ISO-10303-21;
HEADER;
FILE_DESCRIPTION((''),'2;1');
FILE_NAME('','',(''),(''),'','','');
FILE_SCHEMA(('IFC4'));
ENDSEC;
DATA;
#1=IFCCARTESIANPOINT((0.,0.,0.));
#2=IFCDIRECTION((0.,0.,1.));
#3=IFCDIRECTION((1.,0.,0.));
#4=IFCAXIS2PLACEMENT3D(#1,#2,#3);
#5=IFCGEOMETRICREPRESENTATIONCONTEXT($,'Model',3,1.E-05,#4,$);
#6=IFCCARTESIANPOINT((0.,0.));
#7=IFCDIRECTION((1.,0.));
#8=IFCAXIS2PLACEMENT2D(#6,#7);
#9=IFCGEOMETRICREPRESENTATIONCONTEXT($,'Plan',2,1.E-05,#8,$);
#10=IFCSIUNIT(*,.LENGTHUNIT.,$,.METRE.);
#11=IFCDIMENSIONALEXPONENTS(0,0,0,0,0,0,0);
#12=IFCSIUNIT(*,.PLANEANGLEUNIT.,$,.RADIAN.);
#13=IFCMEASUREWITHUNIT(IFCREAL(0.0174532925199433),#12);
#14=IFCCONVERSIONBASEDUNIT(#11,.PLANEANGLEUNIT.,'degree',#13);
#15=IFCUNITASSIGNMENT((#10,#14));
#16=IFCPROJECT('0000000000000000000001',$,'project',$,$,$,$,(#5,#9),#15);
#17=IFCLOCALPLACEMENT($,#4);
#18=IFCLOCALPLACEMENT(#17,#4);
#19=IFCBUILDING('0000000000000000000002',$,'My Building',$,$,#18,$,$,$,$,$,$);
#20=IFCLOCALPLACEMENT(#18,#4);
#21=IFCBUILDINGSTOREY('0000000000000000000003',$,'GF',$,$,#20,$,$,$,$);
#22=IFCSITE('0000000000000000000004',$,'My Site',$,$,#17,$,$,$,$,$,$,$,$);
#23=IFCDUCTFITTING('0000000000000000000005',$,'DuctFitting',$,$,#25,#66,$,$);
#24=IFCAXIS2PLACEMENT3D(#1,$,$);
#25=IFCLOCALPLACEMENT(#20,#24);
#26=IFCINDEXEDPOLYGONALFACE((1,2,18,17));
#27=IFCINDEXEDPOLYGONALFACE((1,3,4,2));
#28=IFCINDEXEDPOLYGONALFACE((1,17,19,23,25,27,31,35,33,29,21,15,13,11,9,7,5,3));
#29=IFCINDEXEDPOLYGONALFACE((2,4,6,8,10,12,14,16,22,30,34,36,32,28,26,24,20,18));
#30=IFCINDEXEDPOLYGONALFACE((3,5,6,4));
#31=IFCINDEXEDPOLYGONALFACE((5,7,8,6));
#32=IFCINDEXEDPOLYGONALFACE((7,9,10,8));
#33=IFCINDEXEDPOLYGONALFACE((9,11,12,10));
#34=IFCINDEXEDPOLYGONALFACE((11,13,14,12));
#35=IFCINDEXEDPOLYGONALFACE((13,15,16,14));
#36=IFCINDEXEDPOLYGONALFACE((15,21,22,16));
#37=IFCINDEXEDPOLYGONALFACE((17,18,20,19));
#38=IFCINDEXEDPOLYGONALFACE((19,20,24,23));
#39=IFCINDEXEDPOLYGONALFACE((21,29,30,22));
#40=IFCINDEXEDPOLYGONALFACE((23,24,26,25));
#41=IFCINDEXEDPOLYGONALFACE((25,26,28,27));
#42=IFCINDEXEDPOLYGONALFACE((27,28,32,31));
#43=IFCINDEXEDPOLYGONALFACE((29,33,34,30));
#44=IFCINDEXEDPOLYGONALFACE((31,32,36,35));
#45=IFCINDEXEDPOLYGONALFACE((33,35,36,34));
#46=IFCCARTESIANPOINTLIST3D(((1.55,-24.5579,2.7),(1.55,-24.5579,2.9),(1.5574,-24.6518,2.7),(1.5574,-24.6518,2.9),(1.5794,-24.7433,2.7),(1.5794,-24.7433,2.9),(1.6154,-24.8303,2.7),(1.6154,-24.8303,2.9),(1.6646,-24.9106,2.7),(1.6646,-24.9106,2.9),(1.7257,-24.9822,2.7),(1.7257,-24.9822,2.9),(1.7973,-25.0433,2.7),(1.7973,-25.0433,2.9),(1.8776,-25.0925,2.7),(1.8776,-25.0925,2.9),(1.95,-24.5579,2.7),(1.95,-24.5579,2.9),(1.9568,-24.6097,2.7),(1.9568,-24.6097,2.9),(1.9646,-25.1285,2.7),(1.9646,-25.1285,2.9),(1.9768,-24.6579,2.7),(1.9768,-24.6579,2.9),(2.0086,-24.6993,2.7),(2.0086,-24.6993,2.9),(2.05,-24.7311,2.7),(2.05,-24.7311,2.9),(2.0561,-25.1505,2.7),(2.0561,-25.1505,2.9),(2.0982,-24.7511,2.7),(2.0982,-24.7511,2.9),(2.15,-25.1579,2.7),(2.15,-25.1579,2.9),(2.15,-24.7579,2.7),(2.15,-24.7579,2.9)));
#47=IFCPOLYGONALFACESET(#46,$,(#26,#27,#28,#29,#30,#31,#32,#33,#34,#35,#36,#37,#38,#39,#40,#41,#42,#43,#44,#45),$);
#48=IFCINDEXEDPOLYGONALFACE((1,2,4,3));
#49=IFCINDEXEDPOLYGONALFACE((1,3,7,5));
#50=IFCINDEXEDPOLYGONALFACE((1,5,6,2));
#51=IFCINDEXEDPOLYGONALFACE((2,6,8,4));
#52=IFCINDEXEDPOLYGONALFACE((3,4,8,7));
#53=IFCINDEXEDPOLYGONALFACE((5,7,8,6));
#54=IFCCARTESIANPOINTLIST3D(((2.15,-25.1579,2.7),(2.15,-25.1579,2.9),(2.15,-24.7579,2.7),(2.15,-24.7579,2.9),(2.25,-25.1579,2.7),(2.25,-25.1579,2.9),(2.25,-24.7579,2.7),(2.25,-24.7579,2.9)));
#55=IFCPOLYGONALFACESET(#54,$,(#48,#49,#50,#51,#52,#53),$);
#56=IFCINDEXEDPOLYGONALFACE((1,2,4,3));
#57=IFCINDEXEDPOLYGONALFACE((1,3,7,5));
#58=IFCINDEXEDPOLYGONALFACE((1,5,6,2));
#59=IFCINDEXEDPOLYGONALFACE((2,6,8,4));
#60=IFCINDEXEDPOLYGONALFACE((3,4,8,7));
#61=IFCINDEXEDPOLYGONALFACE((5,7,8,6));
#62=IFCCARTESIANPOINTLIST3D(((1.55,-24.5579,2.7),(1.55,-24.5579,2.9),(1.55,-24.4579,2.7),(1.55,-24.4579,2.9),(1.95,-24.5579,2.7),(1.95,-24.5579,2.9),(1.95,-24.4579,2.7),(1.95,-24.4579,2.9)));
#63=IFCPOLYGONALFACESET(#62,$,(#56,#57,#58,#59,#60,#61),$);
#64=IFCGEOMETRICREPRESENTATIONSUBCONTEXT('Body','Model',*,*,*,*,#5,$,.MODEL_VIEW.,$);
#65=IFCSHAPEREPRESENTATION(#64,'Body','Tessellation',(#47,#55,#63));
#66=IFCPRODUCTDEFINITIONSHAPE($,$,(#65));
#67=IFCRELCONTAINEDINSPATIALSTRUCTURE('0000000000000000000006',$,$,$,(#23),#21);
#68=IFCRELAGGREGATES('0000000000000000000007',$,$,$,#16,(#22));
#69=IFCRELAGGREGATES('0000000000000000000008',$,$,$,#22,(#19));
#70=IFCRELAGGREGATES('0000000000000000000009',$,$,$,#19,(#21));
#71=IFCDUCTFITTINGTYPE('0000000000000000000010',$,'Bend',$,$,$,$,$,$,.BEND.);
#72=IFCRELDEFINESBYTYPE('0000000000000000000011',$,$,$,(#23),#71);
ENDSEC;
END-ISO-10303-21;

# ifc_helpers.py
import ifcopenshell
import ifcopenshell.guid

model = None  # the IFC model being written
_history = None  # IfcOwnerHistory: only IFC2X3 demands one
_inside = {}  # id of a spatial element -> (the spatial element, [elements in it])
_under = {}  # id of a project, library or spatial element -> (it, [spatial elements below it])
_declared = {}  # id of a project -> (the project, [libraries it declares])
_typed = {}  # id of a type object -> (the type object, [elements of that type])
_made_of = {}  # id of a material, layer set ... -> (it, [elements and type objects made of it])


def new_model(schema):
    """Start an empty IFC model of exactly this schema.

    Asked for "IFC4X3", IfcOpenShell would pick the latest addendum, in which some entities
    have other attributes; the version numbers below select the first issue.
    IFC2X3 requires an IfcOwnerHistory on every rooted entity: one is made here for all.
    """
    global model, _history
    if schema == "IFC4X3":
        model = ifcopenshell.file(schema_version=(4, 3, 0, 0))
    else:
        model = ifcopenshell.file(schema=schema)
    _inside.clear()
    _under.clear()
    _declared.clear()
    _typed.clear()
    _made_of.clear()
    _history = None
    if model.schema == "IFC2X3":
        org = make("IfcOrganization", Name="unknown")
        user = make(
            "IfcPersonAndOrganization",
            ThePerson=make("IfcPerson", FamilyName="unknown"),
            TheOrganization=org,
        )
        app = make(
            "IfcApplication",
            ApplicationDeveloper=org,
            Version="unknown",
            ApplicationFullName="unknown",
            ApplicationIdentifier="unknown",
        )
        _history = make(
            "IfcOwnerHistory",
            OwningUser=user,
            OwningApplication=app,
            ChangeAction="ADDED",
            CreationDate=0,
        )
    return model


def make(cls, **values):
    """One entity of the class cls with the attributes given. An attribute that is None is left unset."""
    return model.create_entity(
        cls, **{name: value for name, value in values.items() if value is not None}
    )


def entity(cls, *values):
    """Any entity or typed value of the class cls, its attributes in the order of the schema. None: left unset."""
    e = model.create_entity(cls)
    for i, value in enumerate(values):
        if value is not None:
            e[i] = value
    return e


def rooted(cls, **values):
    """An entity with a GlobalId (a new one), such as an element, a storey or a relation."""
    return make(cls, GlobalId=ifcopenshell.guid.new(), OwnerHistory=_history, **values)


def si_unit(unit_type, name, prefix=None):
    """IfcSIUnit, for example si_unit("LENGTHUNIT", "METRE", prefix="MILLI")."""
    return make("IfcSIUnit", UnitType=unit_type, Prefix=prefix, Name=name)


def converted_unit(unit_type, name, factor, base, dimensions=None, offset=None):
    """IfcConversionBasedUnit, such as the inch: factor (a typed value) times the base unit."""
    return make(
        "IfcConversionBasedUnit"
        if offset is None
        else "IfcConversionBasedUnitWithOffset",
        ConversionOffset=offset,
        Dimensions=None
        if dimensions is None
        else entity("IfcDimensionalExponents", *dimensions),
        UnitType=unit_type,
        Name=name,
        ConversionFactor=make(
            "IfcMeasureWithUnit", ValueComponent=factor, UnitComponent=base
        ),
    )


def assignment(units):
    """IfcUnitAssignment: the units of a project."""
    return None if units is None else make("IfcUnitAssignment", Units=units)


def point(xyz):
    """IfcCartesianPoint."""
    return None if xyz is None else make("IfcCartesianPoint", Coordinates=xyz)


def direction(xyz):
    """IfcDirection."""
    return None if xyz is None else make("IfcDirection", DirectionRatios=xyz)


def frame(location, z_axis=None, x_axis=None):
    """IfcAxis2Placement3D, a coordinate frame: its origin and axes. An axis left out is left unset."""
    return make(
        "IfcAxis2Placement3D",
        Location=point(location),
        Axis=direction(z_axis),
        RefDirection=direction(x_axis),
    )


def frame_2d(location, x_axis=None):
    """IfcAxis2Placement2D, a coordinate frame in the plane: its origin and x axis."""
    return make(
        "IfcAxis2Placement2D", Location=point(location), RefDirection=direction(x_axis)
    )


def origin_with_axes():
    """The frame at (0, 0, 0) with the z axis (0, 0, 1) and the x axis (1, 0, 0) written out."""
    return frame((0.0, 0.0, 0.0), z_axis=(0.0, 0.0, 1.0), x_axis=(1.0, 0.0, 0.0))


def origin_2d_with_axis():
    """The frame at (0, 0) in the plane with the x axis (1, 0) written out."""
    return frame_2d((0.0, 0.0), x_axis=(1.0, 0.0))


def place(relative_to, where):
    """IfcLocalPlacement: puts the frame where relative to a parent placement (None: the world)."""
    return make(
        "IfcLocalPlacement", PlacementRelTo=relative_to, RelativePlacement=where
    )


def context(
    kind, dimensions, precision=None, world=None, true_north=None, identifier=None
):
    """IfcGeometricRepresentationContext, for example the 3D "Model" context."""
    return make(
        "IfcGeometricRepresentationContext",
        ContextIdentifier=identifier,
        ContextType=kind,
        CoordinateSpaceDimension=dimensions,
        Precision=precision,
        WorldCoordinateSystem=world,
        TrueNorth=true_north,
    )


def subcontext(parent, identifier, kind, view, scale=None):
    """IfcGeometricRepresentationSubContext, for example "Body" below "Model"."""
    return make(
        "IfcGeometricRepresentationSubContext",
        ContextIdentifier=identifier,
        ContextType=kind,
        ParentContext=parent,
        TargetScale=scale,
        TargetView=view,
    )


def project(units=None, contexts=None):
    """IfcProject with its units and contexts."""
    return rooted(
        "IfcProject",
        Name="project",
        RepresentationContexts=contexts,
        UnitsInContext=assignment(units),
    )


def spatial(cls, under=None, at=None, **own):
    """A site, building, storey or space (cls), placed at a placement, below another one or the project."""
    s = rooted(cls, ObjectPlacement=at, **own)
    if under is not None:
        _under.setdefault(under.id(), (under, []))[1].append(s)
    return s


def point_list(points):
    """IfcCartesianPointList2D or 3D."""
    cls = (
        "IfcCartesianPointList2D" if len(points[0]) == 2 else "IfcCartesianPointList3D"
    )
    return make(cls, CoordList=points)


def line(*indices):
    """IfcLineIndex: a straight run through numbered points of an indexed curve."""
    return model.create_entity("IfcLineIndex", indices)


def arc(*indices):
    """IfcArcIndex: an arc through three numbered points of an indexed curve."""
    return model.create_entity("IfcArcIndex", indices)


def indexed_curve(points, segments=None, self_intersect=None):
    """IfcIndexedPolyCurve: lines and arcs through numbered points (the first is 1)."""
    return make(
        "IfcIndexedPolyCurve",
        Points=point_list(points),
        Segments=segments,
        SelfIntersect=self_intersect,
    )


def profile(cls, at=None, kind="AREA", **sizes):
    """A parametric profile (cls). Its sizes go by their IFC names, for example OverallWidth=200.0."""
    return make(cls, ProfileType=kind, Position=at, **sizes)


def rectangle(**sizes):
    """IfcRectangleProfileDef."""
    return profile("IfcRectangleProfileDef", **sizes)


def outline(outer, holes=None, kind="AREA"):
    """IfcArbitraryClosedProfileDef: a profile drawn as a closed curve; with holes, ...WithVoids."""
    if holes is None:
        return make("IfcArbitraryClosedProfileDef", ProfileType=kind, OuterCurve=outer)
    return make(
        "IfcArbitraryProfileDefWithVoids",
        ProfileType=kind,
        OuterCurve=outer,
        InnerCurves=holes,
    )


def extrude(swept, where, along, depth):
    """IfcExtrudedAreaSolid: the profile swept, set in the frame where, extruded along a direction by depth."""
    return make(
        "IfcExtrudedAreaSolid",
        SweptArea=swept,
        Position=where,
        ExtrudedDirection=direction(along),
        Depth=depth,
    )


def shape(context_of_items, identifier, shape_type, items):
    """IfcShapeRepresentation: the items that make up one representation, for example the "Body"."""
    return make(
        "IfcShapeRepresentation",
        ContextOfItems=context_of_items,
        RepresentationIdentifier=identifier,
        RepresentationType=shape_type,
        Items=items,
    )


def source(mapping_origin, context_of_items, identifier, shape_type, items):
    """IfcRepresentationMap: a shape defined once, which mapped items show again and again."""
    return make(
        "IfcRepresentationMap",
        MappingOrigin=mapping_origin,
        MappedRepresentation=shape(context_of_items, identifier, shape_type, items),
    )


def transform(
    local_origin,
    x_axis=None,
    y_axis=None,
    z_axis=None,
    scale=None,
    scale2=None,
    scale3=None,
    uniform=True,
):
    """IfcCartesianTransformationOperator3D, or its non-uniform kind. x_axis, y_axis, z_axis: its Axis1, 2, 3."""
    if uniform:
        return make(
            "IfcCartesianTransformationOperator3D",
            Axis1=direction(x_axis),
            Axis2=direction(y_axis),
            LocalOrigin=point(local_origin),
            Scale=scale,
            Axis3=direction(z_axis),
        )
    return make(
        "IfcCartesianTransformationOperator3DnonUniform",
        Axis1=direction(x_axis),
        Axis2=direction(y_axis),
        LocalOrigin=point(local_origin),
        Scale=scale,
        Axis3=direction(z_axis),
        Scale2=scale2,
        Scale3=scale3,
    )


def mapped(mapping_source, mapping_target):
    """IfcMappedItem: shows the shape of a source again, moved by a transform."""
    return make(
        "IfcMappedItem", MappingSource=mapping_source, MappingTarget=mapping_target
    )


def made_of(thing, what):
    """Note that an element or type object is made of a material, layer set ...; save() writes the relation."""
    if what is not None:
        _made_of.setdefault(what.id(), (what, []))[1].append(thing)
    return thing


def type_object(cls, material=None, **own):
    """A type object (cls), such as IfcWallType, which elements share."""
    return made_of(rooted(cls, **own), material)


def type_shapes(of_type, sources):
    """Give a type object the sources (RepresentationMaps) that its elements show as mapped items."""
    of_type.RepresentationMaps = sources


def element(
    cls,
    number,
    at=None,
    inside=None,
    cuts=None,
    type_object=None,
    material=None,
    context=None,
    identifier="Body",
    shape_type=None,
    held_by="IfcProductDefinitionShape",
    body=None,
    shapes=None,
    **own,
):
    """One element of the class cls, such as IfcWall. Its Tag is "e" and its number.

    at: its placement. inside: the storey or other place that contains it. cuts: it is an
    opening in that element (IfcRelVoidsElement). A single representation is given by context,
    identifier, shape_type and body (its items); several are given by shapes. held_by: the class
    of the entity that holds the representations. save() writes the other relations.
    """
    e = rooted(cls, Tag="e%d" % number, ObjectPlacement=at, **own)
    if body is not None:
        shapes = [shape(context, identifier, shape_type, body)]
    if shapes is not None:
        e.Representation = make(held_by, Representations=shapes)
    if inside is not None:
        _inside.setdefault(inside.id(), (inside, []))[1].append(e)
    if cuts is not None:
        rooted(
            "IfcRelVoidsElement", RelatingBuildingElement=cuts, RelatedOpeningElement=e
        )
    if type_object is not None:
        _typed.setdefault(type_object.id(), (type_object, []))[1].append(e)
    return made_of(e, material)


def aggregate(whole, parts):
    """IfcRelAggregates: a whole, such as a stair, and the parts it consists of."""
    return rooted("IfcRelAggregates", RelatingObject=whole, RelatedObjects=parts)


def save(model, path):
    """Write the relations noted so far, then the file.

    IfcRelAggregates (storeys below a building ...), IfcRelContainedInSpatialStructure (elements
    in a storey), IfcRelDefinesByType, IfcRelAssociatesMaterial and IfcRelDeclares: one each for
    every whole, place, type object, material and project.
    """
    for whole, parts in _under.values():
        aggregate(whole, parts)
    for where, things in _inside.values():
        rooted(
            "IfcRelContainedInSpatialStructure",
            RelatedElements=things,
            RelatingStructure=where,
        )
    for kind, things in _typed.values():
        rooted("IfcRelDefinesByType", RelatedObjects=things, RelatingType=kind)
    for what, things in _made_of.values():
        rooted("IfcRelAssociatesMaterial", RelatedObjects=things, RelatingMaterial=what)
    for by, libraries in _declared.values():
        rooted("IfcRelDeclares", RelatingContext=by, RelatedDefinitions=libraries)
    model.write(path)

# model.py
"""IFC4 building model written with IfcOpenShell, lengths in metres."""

from ifc_helpers import new_model, entity, si_unit, converted_unit, frame, origin_with_axes, origin_2d_with_axis, place, context, subcontext, project, spatial, line, arc, indexed_curve, rectangle, outline, extrude, source, transform, mapped, type_object, type_shapes, element, save


model = new_model("IFC4")

# Units and contexts
model_context = context("Model", 3, precision=1e-05, world=origin_with_axes())
plan_context = context("Plan", 2, precision=1e-05, world=origin_2d_with_axis())
body_context_1 = subcontext(model_context, "Body", "Model", "MODEL_VIEW")
ifc_project = project(units=[si_unit("LENGTHUNIT", "METRE"), converted_unit("PLANEANGLEUNIT", "degree", entity("IfcReal", 0.0174532925199433), si_unit("PLANEANGLEUNIT", "RADIAN"), dimensions=[0, 0, 0, 0, 0, 0, 0])], contexts=[model_context, plan_context])

# Site, building, storey
site_placement = place(None, origin_with_axes())
site = spatial("IfcSite", under=ifc_project, at=site_placement, Name="My Site")
building_placement = place(site_placement, origin_with_axes())
building = spatial("IfcBuilding", under=site, at=building_placement, Name="My Building")
storey_placement = place(building_placement, origin_with_axes())
storey = spatial("IfcBuildingStorey", under=building, at=storey_placement, Name="GF")

# Duct fitting
duct_fitting_type = type_object("IfcDuctFittingType", Name="Bend", PredefinedType="BEND")
shared_shape_1 = source(origin_with_axes(), body_context_1, "Body", "SweptSolid", [
    extrude(outline(indexed_curve([(-0.2, 0.0), (-0.2586, -0.1414), (-0.4, -0.2), (-0.4, -0.6), (0.0243, -0.4243), (0.2, 0.0)], segments=[arc(1, 2, 3), line(3, 4), arc(4, 5, 6), line(6, 1)])), frame((0.0, -0.1, -0.1), z_axis=(0.0, -1.0, 0.0), x_axis=(1.0, 0.0, 0.0)), (0.0, 0.0, -1.0), 0.2),
    extrude(rectangle(XDim=0.4, YDim=0.2), origin_with_axes(), (0.0, 0.0, -1.0), 0.1),
    extrude(rectangle(XDim=0.4, YDim=0.2), frame((-0.4, 0.0, -0.5), z_axis=(-1.0, 0.0, 0.0), x_axis=(0.0, 0.0, -1.0)), (0.0, 0.0, 1.0), 0.1),
])
type_shapes(duct_fitting_type, [shared_shape_1])
for number, where, z_axis, x_axis, name in (
    (1, (2.25, -24.9579, 2.8), (1.0, 0.0, 0.0), (0.0, -1.0, 0.0), "DuctFitting"),
):
    element("IfcDuctFitting", number, at=place(storey_placement, frame(where, z_axis=z_axis, x_axis=x_axis)), inside=storey, type_object=duct_fitting_type, Name=name, context=body_context_1, shape_type="MappedRepresentation", body=[
        mapped(shared_shape_1, transform((0.0, 0.0, 0.0), x_axis=(1.0, 0.0, 0.0), y_axis=(0.0, 1.0, 0.0), z_axis=(0.0, 0.0, 1.0), scale=1.0)),
    ])

save(model, "model.ifc")
